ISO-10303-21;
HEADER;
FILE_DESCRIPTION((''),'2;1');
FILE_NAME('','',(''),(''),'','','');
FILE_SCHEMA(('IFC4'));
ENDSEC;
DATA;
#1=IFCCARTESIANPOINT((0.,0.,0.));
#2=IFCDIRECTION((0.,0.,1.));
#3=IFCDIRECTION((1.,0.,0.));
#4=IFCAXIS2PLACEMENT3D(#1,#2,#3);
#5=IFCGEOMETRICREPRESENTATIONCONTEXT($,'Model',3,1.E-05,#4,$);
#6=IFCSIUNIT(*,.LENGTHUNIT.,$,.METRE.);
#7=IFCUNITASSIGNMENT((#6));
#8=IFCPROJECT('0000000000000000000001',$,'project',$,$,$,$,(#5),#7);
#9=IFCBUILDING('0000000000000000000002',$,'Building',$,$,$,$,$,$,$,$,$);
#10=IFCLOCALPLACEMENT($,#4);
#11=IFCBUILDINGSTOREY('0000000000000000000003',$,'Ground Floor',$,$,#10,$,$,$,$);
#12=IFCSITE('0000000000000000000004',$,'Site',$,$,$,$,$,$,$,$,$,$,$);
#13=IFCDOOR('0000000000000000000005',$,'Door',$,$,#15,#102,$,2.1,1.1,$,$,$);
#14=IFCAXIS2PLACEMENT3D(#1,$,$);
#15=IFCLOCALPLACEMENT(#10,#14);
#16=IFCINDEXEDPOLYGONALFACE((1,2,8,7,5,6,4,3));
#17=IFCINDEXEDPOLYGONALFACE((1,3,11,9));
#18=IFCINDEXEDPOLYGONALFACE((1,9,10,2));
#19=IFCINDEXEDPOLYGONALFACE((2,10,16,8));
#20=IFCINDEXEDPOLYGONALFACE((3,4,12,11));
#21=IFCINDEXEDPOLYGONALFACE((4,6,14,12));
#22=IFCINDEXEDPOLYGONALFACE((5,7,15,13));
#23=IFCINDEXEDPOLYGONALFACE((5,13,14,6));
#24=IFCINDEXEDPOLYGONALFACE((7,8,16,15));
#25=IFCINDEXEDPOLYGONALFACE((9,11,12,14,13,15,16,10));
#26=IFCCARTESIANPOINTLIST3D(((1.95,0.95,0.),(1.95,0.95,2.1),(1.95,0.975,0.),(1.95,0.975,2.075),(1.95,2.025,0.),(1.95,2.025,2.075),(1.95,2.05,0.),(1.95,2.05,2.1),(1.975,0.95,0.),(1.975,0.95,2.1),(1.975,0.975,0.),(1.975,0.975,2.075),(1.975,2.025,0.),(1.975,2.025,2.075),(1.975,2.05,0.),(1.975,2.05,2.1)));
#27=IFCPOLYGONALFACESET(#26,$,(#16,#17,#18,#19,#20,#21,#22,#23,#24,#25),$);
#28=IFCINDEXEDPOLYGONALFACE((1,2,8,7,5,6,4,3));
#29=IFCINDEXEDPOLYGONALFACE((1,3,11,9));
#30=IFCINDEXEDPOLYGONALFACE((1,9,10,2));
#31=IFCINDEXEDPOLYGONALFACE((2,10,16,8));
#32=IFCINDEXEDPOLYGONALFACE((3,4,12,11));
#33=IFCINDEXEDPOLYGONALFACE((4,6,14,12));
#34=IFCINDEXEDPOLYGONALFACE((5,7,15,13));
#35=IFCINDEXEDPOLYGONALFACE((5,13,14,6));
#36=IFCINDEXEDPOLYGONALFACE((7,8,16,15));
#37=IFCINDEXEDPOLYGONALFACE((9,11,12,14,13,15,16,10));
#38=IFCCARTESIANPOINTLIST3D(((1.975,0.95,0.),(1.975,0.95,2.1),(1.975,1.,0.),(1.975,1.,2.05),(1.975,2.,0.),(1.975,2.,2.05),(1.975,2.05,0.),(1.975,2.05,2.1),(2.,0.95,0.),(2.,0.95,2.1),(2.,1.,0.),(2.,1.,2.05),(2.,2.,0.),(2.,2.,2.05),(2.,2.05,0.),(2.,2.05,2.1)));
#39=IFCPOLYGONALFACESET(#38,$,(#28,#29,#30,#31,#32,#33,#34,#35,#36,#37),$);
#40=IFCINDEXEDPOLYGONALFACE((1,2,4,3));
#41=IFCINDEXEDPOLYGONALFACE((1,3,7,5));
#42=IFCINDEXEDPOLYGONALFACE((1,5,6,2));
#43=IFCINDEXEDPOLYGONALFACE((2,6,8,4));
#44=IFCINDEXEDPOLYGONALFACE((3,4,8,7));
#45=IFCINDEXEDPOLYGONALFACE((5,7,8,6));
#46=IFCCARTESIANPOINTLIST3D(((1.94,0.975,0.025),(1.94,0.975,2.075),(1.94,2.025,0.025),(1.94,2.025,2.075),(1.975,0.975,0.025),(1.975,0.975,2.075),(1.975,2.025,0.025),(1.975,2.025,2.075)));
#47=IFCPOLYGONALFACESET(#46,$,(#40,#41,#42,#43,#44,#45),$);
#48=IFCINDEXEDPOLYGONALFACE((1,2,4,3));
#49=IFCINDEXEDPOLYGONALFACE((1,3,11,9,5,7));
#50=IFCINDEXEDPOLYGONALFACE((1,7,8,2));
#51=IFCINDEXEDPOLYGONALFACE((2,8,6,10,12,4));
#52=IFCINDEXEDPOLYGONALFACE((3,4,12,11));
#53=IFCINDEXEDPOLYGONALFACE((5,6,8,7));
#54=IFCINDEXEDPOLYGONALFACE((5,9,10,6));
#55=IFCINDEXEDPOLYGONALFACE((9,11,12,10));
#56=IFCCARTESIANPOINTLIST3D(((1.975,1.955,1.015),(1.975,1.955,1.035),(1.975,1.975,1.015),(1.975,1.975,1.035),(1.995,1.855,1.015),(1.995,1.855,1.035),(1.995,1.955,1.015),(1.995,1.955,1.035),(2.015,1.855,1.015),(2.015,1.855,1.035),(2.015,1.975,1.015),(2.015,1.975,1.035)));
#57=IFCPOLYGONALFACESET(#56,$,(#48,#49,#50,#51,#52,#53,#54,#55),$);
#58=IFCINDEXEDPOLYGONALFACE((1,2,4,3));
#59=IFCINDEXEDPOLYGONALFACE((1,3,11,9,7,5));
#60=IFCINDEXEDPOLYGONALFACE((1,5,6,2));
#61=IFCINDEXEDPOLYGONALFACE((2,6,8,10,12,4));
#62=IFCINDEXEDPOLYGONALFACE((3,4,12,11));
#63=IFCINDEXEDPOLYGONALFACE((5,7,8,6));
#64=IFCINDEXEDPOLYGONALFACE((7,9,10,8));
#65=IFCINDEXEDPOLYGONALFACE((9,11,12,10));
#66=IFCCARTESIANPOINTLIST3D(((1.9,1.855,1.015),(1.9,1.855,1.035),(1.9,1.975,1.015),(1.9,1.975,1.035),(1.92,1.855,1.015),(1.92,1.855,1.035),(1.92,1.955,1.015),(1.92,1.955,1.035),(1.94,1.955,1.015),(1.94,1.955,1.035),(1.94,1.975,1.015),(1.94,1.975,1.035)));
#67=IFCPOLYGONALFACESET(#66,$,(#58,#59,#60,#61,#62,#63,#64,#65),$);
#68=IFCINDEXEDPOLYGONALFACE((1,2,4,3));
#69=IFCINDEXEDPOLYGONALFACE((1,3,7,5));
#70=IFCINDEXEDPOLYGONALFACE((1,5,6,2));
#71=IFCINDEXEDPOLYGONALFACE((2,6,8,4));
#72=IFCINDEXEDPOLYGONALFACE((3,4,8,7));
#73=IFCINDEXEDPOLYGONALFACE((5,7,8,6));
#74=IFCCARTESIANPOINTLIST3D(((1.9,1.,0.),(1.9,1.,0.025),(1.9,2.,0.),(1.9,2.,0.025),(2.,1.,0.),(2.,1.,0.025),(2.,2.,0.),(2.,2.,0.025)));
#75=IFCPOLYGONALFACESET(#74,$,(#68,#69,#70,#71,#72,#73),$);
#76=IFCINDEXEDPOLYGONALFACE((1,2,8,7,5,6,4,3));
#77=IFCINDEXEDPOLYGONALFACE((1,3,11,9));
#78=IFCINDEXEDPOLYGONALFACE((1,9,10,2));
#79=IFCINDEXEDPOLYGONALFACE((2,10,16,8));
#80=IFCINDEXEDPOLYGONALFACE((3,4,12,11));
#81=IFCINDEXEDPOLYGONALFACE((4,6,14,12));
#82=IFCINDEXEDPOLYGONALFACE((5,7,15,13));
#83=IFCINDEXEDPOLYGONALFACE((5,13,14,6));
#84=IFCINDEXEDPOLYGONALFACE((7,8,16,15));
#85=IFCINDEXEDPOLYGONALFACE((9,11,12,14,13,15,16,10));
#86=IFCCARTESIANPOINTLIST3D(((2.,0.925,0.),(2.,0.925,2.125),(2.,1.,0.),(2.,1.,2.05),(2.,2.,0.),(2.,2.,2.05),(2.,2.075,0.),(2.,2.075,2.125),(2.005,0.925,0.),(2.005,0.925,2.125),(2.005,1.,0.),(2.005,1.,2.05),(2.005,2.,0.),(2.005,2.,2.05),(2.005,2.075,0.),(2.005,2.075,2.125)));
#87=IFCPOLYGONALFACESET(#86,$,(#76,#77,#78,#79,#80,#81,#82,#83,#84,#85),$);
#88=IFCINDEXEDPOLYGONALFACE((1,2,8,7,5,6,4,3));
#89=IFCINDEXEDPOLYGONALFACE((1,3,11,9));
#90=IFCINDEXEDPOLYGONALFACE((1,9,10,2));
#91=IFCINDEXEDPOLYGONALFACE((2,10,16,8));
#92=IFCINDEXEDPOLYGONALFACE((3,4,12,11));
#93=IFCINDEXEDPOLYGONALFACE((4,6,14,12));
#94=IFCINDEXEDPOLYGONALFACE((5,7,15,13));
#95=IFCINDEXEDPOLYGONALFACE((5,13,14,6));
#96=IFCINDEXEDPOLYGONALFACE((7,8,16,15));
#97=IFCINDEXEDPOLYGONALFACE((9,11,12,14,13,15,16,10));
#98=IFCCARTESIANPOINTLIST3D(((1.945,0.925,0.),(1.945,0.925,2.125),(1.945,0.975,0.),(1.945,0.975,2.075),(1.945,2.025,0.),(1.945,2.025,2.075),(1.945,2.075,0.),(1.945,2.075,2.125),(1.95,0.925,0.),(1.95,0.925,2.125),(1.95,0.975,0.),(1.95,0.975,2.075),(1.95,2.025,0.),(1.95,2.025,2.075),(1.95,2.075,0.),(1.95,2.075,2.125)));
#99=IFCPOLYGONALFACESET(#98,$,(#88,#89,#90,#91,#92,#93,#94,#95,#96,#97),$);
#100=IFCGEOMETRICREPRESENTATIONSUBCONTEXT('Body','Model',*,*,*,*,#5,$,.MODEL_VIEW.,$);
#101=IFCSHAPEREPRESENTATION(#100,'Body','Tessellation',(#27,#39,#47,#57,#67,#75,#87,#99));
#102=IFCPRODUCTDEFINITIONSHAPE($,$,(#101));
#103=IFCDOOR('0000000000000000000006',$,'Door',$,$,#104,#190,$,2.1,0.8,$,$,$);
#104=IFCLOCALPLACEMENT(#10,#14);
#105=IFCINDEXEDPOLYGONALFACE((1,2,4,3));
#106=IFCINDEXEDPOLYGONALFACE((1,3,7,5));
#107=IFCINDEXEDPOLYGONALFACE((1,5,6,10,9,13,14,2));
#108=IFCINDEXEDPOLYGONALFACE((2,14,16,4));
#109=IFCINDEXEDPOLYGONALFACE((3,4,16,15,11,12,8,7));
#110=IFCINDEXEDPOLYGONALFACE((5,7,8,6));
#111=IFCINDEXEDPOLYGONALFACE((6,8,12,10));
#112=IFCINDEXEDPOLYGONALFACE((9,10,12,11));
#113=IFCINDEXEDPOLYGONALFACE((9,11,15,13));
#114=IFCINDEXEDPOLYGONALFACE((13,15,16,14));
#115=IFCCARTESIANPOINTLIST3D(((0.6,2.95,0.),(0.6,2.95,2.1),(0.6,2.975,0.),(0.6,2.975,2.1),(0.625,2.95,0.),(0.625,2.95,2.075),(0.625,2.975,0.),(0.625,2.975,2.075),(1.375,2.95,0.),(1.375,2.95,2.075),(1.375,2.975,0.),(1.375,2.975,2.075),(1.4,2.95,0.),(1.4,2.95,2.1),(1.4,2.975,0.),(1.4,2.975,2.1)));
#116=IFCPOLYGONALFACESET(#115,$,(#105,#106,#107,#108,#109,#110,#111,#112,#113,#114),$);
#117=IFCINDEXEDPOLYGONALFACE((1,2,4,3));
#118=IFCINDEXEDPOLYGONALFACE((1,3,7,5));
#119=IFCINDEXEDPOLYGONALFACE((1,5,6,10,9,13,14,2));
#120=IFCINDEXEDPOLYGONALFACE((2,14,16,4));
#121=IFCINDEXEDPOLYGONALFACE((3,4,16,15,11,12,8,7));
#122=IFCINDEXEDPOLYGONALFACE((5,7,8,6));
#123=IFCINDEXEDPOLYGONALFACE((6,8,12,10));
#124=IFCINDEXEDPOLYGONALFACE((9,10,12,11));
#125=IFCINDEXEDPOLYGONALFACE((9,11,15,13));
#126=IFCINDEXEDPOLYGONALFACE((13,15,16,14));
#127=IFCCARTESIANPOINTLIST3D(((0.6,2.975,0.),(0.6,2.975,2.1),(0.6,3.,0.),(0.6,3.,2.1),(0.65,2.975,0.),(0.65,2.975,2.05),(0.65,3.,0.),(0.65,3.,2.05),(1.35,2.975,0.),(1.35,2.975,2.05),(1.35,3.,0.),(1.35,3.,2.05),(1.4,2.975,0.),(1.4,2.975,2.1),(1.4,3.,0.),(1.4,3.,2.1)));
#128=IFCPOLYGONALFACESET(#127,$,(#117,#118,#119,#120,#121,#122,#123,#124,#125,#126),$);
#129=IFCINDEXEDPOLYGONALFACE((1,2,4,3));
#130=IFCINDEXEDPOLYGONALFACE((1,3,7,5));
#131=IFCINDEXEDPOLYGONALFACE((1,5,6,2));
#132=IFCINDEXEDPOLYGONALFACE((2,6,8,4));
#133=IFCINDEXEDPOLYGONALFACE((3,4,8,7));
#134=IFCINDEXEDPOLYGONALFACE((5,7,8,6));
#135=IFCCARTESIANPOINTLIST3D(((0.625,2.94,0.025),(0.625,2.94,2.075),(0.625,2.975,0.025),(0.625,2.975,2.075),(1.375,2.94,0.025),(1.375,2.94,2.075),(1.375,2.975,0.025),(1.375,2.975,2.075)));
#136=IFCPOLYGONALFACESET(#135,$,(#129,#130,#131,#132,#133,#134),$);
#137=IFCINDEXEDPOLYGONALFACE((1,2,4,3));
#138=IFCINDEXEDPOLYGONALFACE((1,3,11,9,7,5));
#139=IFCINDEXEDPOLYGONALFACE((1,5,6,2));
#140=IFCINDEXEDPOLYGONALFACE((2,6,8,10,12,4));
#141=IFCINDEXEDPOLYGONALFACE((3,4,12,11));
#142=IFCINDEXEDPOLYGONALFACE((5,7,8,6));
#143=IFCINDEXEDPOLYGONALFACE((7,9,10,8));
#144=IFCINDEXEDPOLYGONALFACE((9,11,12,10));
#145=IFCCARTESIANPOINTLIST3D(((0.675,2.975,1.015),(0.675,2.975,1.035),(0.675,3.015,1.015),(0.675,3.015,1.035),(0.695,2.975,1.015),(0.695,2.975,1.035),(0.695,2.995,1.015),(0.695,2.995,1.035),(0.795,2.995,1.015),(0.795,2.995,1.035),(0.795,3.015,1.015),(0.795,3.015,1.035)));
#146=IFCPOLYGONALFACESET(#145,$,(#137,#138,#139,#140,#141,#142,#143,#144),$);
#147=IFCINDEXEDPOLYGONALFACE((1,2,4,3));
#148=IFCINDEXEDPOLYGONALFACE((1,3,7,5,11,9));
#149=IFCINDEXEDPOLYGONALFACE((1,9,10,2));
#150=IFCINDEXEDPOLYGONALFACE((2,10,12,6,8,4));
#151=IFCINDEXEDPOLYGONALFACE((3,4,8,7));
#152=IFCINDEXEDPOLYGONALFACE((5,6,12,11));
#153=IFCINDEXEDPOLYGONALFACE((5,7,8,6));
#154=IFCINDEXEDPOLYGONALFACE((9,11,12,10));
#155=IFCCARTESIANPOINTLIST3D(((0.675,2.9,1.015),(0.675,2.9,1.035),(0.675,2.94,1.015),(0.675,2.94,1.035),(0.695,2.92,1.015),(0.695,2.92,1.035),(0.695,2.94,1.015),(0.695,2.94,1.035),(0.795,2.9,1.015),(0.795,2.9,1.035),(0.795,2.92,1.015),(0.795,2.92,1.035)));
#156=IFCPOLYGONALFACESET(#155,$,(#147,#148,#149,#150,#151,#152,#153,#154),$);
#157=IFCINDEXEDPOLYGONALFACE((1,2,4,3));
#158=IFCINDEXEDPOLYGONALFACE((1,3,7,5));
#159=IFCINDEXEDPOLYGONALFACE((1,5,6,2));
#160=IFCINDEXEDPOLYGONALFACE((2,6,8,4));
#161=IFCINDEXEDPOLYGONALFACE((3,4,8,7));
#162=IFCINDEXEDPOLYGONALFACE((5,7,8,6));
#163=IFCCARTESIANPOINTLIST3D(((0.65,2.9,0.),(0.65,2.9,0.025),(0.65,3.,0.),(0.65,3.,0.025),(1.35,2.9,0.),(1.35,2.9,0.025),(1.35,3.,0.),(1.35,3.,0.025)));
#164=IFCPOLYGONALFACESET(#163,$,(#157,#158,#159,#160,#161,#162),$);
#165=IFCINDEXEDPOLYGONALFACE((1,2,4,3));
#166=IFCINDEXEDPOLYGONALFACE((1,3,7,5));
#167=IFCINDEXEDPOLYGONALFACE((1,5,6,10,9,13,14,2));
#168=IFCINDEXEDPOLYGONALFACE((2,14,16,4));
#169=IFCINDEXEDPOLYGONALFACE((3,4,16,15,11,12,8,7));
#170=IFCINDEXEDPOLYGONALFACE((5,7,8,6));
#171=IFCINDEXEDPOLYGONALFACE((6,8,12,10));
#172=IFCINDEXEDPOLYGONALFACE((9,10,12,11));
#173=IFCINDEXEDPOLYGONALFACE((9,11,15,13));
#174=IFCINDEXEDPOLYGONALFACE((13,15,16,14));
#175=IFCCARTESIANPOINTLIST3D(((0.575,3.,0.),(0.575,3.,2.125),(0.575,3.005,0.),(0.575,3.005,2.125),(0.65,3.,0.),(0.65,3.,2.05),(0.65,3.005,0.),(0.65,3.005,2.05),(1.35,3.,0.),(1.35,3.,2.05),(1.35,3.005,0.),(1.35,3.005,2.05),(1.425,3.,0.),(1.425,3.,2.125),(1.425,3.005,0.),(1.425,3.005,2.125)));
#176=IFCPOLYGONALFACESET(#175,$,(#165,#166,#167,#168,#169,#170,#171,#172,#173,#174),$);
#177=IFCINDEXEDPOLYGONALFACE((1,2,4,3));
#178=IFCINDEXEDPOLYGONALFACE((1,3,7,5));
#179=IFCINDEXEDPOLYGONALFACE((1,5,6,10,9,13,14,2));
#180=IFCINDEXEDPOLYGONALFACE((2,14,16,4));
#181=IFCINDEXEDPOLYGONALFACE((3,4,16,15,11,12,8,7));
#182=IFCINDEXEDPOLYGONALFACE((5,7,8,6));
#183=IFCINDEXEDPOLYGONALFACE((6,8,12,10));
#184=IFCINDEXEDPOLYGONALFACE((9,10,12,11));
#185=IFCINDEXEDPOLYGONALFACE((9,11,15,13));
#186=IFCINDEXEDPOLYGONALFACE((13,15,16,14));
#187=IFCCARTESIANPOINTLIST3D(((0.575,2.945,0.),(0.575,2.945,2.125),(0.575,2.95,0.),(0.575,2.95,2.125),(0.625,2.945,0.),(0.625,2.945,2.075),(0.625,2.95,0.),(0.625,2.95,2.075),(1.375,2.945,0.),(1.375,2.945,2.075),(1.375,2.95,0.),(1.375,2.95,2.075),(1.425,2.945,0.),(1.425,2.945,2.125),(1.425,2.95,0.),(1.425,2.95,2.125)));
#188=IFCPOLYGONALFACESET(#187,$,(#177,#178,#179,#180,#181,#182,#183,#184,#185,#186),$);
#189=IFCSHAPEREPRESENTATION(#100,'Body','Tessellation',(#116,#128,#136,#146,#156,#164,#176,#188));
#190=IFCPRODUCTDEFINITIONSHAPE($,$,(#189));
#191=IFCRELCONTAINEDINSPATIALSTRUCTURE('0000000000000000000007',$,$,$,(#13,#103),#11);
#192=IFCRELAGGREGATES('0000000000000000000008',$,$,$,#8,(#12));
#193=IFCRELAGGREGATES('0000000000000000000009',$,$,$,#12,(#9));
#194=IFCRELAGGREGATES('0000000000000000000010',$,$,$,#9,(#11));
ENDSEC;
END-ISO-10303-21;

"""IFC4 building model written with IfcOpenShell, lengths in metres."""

from ifc_helpers import new_model, si_unit, frame, origin_with_axes, place, context, subcontext, project, spatial, line, indexed_curve, outline, extrude, element, save


model = new_model("IFC4")

# Units and contexts
model_context = context("Model", 3, precision=1e-05, world=origin_with_axes())
body_context = subcontext(model_context, "Body", "Model", "MODEL_VIEW")
ifc_project = project(units=[si_unit("LENGTHUNIT", "METRE")], contexts=[model_context])

# Site, building, storey
site = spatial("IfcSite", under=ifc_project, Name="Site")
building = spatial("IfcBuilding", under=site, Name="Building")
storey_placement = place(None, origin_with_axes())
storey = spatial("IfcBuildingStorey", under=building, at=storey_placement, Name="Ground Floor")

# Doors
door_1_placement = place(storey_placement, frame((2.0, 0.95, 0.0), z_axis=(0.0, 0.0, 1.0), x_axis=(0.0, 1.0, 0.0)))
element("IfcDoor", 1, at=door_1_placement, inside=storey, Name="Door", OverallHeight=2.1, OverallWidth=1.1, context=body_context, shape_type="SweptSolid", body=[
    extrude(outline(indexed_curve([(0.0, 0.0), (0.0, 2.1), (1.1, 2.1), (1.1, 0.0), (1.075, 0.0), (1.075, 2.075), (0.025, 2.075), (0.025, 0.0)], segments=[line(1, 2, 3, 4, 5, 6, 7, 8, 1)])), frame((0.0, 0.025, 0.0), z_axis=(0.0, -1.0, 0.0), x_axis=(1.0, 0.0, 0.0)), (0.0, 0.0, -1.0), 0.025),
    extrude(outline(indexed_curve([(0.0, 0.0), (0.0, 2.1), (1.1, 2.1), (1.1, 0.0), (1.05, 0.0), (1.05, 2.05), (0.05, 2.05), (0.05, 0.0)], segments=[line(1, 2, 3, 4, 5, 6, 7, 8, 1)])), frame((0.0, 0.0, 0.0), z_axis=(0.0, -1.0, 0.0), x_axis=(1.0, 0.0, 0.0)), (0.0, 0.0, -1.0), 0.025),
    extrude(outline(indexed_curve([(0.0, 0.0), (1.05, 0.0), (1.05, 0.035), (0.0, 0.035)], segments=[line(1, 2, 3, 4, 1)])), frame((0.025, 0.025, 0.025), z_axis=(0.0, 0.0, 1.0), x_axis=(1.0, 0.0, 0.0)), (0.0, 0.0, 1.0), 2.05),
    extrude(outline(indexed_curve([(0.0, 0.0), (0.0, -0.04), (-0.12, -0.04), (-0.12, -0.02), (-0.02, -0.02), (-0.02, 0.0)], segments=[line(1, 2, 3, 4, 5, 6, 1)])), frame((1.025, 0.025, 1.015), z_axis=(0.0, 0.0, 1.0), x_axis=(1.0, 0.0, 0.0)), (0.0, 0.0, 1.0), 0.02),
    extrude(outline(indexed_curve([(0.0, 0.0), (0.0, 0.04), (-0.12, 0.04), (-0.12, 0.02), (-0.02, 0.02), (-0.02, 0.0)], segments=[line(1, 2, 3, 4, 5, 6, 1)])), frame((1.025, 0.06, 1.015), z_axis=(0.0, 0.0, 1.0), x_axis=(1.0, 0.0, 0.0)), (0.0, 0.0, 1.0), 0.02),
    extrude(outline(indexed_curve([(0.0, 0.0), (1.0, 0.0), (1.0, 0.1), (0.0, 0.1)], segments=[line(1, 2, 3, 4, 1)])), frame((0.05, 0.0, 0.0), z_axis=(0.0, 0.0, 1.0), x_axis=(1.0, 0.0, 0.0)), (0.0, 0.0, 1.0), 0.025),
    extrude(outline(indexed_curve([(0.0, 0.0), (0.0, 2.125), (1.15, 2.125), (1.15, 0.0), (1.075, 0.0), (1.075, 2.05), (0.075, 2.05), (0.075, 0.0)], segments=[line(1, 2, 3, 4, 5, 6, 7, 8, 1)])), frame((-0.025, -0.005, 0.0), z_axis=(0.0, -1.0, 0.0), x_axis=(1.0, 0.0, 0.0)), (0.0, 0.0, -1.0), 0.005),
    extrude(outline(indexed_curve([(0.0, 0.0), (0.0, 2.125), (1.15, 2.125), (1.15, 0.0), (1.1, 0.0), (1.1, 2.075), (0.05, 2.075), (0.05, 0.0)], segments=[line(1, 2, 3, 4, 5, 6, 7, 8, 1)])), frame((-0.025, 0.05, 0.0), z_axis=(0.0, -1.0, 0.0), x_axis=(1.0, 0.0, 0.0)), (0.0, 0.0, -1.0), 0.005),
])
door_2_placement = place(storey_placement, frame((1.4, 3.0, 0.0), z_axis=(0.0, 0.0, 1.0), x_axis=(-1.0, 0.0, 0.0)))
element("IfcDoor", 2, at=door_2_placement, inside=storey, Name="Door", OverallHeight=2.1, OverallWidth=0.8, context=body_context, shape_type="SweptSolid", body=[
    extrude(outline(indexed_curve([(0.0, 0.0), (0.0, 2.1), (0.8, 2.1), (0.8, 0.0), (0.775, 0.0), (0.775, 2.075), (0.025, 2.075), (0.025, 0.0)], segments=[line(1, 2, 3, 4, 5, 6, 7, 8, 1)])), frame((0.0, 0.025, 0.0), z_axis=(0.0, -1.0, 0.0), x_axis=(1.0, 0.0, 0.0)), (0.0, 0.0, -1.0), 0.025),
    extrude(outline(indexed_curve([(0.0, 0.0), (0.0, 2.1), (0.8, 2.1), (0.8, 0.0), (0.75, 0.0), (0.75, 2.05), (0.05, 2.05), (0.05, 0.0)], segments=[line(1, 2, 3, 4, 5, 6, 7, 8, 1)])), frame((0.0, 0.0, 0.0), z_axis=(0.0, -1.0, 0.0), x_axis=(1.0, 0.0, 0.0)), (0.0, 0.0, -1.0), 0.025),
    extrude(outline(indexed_curve([(0.0, 0.0), (0.75, 0.0), (0.75, 0.035), (0.0, 0.035)], segments=[line(1, 2, 3, 4, 1)])), frame((0.025, 0.025, 0.025), z_axis=(0.0, 0.0, 1.0), x_axis=(1.0, 0.0, 0.0)), (0.0, 0.0, 1.0), 2.05),
    extrude(outline(indexed_curve([(0.0, 0.0), (0.0, -0.04), (-0.12, -0.04), (-0.12, -0.02), (-0.02, -0.02), (-0.02, 0.0)], segments=[line(1, 2, 3, 4, 5, 6, 1)])), frame((0.725, 0.025, 1.015), z_axis=(0.0, 0.0, 1.0), x_axis=(1.0, 0.0, 0.0)), (0.0, 0.0, 1.0), 0.02),
    extrude(outline(indexed_curve([(0.0, 0.0), (0.0, 0.04), (-0.12, 0.04), (-0.12, 0.02), (-0.02, 0.02), (-0.02, 0.0)], segments=[line(1, 2, 3, 4, 5, 6, 1)])), frame((0.725, 0.06, 1.015), z_axis=(0.0, 0.0, 1.0), x_axis=(1.0, 0.0, 0.0)), (0.0, 0.0, 1.0), 0.02),
    extrude(outline(indexed_curve([(0.0, 0.0), (0.7, 0.0), (0.7, 0.1), (0.0, 0.1)], segments=[line(1, 2, 3, 4, 1)])), frame((0.05, 0.0, 0.0), z_axis=(0.0, 0.0, 1.0), x_axis=(1.0, 0.0, 0.0)), (0.0, 0.0, 1.0), 0.025),
    extrude(outline(indexed_curve([(0.0, 0.0), (0.0, 2.125), (0.85, 2.125), (0.85, 0.0), (0.775, 0.0), (0.775, 2.05), (0.075, 2.05), (0.075, 0.0)], segments=[line(1, 2, 3, 4, 5, 6, 7, 8, 1)])), frame((-0.025, -0.005, 0.0), z_axis=(0.0, -1.0, 0.0), x_axis=(1.0, 0.0, 0.0)), (0.0, 0.0, -1.0), 0.005),
    extrude(outline(indexed_curve([(0.0, 0.0), (0.0, 2.125), (0.85, 2.125), (0.85, 0.0), (0.8, 0.0), (0.8, 2.075), (0.05, 2.075), (0.05, 0.0)], segments=[line(1, 2, 3, 4, 5, 6, 7, 8, 1)])), frame((-0.025, 0.05, 0.0), z_axis=(0.0, -1.0, 0.0), x_axis=(1.0, 0.0, 0.0)), (0.0, 0.0, -1.0), 0.005),
])

save(model, "model.ifc")
